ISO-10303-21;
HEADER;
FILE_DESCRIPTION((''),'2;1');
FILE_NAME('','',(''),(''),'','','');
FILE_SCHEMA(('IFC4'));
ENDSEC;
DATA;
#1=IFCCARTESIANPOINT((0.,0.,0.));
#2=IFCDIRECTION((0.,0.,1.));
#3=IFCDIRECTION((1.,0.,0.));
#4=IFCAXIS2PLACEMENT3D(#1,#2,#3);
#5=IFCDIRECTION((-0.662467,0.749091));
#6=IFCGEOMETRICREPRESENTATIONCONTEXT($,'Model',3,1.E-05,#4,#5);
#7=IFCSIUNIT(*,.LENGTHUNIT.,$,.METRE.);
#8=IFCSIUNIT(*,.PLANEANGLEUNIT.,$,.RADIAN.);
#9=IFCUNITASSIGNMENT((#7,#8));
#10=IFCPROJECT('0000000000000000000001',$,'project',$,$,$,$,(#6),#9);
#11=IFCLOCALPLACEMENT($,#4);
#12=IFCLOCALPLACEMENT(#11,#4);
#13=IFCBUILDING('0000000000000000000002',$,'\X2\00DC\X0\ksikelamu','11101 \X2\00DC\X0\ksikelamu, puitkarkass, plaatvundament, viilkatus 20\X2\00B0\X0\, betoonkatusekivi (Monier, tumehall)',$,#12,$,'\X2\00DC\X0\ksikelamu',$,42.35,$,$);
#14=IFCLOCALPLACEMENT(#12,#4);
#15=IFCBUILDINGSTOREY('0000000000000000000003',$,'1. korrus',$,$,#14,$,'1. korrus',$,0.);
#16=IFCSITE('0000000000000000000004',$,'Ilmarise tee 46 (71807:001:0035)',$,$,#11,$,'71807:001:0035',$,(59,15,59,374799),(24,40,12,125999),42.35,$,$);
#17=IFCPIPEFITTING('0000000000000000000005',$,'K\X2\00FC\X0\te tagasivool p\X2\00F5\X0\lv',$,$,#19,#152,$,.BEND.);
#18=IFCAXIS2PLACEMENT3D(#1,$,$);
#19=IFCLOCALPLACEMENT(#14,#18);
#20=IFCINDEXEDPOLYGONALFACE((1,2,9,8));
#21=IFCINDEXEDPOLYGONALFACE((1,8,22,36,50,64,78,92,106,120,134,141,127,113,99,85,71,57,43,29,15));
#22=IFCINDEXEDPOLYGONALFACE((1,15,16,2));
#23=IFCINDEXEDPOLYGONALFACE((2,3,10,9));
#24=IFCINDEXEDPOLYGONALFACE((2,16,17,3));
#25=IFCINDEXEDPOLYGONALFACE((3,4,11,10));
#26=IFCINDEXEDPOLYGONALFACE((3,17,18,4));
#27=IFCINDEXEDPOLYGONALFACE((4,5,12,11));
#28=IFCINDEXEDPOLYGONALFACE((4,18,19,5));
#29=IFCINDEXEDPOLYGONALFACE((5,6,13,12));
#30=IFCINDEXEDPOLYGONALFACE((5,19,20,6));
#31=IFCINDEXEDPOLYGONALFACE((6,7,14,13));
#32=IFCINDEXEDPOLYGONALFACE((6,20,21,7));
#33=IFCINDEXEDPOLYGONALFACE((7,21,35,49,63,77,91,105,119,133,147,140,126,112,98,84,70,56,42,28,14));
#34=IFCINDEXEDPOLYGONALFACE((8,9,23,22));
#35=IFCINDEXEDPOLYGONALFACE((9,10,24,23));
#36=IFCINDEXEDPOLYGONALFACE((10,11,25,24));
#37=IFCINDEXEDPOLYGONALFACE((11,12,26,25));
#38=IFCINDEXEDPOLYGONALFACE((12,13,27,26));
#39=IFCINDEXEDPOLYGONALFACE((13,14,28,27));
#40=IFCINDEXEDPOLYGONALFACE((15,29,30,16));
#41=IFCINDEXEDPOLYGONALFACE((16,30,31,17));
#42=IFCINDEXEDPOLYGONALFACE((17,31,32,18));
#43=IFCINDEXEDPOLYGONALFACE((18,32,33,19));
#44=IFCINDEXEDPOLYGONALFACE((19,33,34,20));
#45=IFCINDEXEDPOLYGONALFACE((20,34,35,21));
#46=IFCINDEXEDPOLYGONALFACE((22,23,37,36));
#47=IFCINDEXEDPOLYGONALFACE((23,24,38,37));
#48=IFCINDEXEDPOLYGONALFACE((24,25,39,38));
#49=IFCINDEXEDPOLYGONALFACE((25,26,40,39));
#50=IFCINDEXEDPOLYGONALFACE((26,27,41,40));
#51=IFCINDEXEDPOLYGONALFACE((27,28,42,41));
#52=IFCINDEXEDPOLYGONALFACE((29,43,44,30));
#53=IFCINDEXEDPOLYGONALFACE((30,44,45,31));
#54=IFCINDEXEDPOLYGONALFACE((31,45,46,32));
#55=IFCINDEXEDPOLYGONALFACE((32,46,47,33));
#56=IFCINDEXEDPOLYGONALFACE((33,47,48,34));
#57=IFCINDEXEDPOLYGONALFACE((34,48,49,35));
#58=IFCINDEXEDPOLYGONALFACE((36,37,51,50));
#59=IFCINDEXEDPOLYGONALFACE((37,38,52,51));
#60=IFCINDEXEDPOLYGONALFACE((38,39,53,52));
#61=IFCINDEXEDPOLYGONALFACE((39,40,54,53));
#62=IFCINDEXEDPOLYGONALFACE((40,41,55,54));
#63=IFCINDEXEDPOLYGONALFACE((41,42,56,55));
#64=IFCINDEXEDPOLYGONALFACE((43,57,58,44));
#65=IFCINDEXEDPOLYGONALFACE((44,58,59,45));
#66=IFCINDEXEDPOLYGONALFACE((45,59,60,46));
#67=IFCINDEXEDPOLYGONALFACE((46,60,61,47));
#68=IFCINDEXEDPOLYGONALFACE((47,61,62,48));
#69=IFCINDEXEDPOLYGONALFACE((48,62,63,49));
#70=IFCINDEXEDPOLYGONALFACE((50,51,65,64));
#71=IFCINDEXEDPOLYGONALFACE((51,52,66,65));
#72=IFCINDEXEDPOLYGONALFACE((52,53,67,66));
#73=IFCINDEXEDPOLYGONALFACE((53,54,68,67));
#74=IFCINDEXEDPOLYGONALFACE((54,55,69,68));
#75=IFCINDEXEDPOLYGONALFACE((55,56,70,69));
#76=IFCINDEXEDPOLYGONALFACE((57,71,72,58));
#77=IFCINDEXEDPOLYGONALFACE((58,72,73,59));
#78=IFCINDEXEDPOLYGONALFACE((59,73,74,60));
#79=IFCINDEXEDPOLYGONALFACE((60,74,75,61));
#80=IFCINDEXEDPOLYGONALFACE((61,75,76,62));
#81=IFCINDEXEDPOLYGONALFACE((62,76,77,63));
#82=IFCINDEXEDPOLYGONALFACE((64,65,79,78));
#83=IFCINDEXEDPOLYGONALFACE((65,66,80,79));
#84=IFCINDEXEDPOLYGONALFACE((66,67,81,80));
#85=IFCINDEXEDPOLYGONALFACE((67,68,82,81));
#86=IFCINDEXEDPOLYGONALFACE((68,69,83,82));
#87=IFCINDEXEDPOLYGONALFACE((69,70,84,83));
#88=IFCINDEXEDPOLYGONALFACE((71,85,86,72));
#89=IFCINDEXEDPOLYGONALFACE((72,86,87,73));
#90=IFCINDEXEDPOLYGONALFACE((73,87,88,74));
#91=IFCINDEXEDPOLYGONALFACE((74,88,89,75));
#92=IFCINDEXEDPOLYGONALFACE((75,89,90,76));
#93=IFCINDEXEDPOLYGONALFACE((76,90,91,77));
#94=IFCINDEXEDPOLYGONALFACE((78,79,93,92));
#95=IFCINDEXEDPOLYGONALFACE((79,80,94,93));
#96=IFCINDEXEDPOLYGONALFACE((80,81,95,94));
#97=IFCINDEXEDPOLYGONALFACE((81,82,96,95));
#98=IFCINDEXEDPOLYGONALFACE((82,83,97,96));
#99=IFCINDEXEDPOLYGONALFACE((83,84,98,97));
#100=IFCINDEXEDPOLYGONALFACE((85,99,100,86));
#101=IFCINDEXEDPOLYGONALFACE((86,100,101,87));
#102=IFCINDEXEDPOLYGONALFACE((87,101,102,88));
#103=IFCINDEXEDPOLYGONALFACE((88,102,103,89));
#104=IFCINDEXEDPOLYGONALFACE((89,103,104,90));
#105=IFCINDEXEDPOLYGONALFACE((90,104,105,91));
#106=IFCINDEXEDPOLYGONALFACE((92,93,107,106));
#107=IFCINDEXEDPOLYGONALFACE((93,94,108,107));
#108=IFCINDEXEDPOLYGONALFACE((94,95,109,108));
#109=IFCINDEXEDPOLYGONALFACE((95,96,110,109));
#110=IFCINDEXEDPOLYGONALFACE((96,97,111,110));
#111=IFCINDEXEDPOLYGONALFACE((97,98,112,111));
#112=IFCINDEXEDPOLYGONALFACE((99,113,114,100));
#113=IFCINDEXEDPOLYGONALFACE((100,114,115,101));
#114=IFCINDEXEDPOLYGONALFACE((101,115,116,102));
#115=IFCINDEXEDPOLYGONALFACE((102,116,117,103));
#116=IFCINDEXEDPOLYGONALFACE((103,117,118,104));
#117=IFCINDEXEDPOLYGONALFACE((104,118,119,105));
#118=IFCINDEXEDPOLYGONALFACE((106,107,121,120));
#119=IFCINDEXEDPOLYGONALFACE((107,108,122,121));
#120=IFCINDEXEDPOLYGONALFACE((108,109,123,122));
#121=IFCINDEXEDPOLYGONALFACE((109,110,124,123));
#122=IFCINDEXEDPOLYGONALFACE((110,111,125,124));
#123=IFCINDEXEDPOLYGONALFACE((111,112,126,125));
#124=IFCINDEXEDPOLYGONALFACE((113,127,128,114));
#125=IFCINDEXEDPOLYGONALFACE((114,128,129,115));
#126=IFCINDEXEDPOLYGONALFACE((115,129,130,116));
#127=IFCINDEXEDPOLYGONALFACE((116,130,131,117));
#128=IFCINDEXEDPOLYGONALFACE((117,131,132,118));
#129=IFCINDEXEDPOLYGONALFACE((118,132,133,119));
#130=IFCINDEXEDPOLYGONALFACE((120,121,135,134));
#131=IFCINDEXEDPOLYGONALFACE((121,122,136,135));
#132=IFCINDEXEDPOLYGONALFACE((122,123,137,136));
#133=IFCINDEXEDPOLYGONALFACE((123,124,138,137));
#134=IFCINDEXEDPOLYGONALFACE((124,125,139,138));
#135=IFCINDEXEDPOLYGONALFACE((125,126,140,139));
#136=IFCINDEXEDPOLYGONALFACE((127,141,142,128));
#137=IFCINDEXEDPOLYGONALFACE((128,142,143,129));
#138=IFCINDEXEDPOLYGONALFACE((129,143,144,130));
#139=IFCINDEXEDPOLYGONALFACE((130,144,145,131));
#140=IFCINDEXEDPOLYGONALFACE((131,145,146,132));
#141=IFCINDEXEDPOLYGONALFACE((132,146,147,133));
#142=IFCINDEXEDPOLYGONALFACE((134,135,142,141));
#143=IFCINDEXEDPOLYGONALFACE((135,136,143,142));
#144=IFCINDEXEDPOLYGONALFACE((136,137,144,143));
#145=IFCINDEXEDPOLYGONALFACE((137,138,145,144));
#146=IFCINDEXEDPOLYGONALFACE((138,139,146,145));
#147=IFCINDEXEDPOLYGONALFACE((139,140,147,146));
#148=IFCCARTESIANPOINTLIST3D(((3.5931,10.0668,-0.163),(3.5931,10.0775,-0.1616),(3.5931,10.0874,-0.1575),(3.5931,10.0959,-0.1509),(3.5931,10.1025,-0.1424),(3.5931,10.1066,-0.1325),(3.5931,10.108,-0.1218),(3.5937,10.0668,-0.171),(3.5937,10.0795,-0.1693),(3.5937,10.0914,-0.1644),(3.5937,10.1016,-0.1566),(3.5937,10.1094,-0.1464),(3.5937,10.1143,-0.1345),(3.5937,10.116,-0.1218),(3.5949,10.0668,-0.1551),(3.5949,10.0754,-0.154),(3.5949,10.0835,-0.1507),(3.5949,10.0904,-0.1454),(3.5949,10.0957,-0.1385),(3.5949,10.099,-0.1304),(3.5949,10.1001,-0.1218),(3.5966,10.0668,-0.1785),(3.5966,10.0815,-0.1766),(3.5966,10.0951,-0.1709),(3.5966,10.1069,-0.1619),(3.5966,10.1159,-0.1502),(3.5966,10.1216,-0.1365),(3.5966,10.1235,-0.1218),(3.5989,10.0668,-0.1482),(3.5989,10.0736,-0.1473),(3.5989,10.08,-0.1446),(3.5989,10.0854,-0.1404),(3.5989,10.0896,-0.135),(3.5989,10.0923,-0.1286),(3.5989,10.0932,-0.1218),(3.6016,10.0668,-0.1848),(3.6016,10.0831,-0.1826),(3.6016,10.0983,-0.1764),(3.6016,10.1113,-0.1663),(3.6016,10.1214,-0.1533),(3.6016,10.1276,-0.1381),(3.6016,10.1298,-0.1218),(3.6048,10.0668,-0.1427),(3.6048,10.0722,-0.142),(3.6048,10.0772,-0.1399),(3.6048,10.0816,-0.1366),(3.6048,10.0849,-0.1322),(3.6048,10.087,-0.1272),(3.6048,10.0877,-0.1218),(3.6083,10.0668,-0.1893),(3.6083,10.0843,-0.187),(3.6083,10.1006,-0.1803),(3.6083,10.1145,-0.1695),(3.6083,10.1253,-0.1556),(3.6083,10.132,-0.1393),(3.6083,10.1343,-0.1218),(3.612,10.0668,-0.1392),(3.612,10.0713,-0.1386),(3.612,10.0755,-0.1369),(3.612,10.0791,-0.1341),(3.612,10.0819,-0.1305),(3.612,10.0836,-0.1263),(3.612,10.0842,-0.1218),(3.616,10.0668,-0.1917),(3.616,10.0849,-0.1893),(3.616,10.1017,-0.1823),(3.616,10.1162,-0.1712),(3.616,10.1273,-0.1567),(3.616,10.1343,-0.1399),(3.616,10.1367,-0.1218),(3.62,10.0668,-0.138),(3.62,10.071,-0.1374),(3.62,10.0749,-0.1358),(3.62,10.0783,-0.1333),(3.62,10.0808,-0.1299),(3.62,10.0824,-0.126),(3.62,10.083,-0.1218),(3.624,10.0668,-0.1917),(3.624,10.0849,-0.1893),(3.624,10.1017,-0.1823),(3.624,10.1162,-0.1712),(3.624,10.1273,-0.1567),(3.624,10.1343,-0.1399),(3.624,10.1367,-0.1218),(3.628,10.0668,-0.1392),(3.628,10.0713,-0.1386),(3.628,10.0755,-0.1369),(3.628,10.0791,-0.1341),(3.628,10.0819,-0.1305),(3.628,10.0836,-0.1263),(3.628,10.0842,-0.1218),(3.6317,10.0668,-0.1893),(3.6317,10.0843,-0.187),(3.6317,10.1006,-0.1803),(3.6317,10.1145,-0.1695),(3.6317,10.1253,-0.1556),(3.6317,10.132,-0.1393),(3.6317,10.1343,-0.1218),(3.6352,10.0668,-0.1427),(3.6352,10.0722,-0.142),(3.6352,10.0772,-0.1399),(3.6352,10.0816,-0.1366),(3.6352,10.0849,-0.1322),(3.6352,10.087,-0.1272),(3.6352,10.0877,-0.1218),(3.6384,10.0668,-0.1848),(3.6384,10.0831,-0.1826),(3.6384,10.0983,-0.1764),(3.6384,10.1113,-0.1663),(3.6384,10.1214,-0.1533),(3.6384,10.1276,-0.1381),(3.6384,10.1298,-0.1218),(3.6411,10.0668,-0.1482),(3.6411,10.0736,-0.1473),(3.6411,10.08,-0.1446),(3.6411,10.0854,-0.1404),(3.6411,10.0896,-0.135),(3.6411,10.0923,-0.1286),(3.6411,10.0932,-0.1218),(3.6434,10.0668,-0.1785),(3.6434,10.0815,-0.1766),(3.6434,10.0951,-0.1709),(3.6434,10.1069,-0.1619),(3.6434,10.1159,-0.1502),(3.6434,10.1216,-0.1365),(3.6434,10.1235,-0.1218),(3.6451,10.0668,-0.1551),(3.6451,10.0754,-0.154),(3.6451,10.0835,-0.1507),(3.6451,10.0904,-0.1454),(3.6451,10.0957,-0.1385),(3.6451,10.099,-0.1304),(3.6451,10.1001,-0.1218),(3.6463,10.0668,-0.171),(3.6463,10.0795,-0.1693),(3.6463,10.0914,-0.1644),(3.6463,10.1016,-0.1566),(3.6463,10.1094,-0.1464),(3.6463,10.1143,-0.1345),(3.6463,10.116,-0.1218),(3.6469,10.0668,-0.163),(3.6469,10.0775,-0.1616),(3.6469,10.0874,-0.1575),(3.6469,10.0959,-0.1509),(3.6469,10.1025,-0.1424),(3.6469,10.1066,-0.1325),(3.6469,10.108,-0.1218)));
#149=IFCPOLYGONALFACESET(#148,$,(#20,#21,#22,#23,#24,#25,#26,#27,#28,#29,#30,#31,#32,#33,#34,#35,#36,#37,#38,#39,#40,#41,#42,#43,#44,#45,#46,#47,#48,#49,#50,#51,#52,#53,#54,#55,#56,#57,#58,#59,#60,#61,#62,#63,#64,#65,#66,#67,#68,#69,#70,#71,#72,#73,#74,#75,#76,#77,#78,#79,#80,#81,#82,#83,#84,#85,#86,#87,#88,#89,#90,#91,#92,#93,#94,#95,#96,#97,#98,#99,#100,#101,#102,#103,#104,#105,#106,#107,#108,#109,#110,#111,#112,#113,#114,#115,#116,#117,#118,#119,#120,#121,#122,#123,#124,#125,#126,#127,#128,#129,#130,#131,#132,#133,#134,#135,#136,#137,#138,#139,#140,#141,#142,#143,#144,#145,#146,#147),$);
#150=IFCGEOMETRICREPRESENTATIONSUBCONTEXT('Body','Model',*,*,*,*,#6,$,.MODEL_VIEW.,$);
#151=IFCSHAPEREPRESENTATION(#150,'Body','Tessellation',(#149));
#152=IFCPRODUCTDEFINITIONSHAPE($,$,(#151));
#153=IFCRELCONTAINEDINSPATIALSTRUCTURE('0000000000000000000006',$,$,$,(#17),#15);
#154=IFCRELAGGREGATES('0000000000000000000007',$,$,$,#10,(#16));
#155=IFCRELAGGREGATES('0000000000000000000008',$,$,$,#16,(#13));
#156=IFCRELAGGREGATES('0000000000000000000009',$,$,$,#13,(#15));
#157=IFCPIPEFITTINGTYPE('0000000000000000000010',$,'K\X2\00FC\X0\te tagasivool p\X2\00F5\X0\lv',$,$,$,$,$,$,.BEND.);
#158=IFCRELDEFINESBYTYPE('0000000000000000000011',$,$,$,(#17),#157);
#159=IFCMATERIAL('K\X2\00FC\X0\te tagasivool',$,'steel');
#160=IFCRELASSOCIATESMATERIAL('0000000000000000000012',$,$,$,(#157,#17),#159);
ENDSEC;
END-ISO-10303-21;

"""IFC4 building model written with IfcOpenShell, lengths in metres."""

from ifc_helpers import new_model, entity, si_unit, direction, frame, origin_with_axes, place, context, subcontext, project, spatial, material, type_object, element, save


model = new_model("IFC4")

# Units and contexts
model_context = context("Model", 3, precision=1e-05, world=origin_with_axes(), true_north=direction((-0.662467, 0.749091)))
body_context = subcontext(model_context, "Body", "Model", "MODEL_VIEW")
ifc_project = project(units=[si_unit("LENGTHUNIT", "METRE"), si_unit("PLANEANGLEUNIT", "RADIAN")], contexts=[model_context])

# Site, building, storey
site_placement = place(None, origin_with_axes())
site = spatial("IfcSite", under=ifc_project, at=site_placement, Name="Ilmarise tee 46 (71807:001:0035)", LongName="71807:001:0035", RefLatitude=(59, 15, 59, 374799), RefLongitude=(24, 40, 12, 125999), RefElevation=42.35)
building_placement = place(site_placement, origin_with_axes())
building = spatial("IfcBuilding", under=site, at=building_placement, Name="Üksikelamu", Description="11101 Üksikelamu, puitkarkass, plaatvundament, viilkatus 20°, betoonkatusekivi (Monier, tumehall)", LongName="Üksikelamu", ElevationOfRefHeight=42.35)
storey_placement = place(building_placement, origin_with_axes())
storey = spatial("IfcBuildingStorey", under=building, at=storey_placement, Name="1. korrus", LongName="1. korrus", Elevation=0.0)

# Pipe fitting
ifc_material_1 = material(Name="Küte tagasivool", Category="steel")
pipe_fitting_type_1 = type_object("IfcPipeFittingType", Name="Küte tagasivool põlv", PredefinedType="BEND", material=ifc_material_1)
pipe_fitting_1_placement = place(storey_placement, frame((3.62, 10.11, -0.165), z_axis=(0.0, 0.0, 1.0), x_axis=(1.0, 0.0, 0.0)))
element("IfcPipeFitting", 1, at=pipe_fitting_1_placement, inside=storey, type_object=pipe_fitting_type_1, material=ifc_material_1, Name="Küte tagasivool põlv", PredefinedType="BEND", context=body_context, shape_type="SweptSolid", body=[
    entity("IfcRevolvedAreaSolid", entity("IfcCircleProfileDef", "AREA", None, None, 0.027), entity("IfcAxis2Placement3D", entity("IfcCartesianPoint", [0.0, -0.0432, 0.0]), entity("IfcDirection", [0.0, 1.0, 0.0]), entity("IfcDirection", [0.0, 0.0, 1.0])), entity("IfcAxis1Placement", entity("IfcCartesianPoint", [0.0432, 0.0, 0.0]), entity("IfcDirection", [0.0, 1.0, 0.0])), 1.570796),
])

save(model, "model.ifc")
